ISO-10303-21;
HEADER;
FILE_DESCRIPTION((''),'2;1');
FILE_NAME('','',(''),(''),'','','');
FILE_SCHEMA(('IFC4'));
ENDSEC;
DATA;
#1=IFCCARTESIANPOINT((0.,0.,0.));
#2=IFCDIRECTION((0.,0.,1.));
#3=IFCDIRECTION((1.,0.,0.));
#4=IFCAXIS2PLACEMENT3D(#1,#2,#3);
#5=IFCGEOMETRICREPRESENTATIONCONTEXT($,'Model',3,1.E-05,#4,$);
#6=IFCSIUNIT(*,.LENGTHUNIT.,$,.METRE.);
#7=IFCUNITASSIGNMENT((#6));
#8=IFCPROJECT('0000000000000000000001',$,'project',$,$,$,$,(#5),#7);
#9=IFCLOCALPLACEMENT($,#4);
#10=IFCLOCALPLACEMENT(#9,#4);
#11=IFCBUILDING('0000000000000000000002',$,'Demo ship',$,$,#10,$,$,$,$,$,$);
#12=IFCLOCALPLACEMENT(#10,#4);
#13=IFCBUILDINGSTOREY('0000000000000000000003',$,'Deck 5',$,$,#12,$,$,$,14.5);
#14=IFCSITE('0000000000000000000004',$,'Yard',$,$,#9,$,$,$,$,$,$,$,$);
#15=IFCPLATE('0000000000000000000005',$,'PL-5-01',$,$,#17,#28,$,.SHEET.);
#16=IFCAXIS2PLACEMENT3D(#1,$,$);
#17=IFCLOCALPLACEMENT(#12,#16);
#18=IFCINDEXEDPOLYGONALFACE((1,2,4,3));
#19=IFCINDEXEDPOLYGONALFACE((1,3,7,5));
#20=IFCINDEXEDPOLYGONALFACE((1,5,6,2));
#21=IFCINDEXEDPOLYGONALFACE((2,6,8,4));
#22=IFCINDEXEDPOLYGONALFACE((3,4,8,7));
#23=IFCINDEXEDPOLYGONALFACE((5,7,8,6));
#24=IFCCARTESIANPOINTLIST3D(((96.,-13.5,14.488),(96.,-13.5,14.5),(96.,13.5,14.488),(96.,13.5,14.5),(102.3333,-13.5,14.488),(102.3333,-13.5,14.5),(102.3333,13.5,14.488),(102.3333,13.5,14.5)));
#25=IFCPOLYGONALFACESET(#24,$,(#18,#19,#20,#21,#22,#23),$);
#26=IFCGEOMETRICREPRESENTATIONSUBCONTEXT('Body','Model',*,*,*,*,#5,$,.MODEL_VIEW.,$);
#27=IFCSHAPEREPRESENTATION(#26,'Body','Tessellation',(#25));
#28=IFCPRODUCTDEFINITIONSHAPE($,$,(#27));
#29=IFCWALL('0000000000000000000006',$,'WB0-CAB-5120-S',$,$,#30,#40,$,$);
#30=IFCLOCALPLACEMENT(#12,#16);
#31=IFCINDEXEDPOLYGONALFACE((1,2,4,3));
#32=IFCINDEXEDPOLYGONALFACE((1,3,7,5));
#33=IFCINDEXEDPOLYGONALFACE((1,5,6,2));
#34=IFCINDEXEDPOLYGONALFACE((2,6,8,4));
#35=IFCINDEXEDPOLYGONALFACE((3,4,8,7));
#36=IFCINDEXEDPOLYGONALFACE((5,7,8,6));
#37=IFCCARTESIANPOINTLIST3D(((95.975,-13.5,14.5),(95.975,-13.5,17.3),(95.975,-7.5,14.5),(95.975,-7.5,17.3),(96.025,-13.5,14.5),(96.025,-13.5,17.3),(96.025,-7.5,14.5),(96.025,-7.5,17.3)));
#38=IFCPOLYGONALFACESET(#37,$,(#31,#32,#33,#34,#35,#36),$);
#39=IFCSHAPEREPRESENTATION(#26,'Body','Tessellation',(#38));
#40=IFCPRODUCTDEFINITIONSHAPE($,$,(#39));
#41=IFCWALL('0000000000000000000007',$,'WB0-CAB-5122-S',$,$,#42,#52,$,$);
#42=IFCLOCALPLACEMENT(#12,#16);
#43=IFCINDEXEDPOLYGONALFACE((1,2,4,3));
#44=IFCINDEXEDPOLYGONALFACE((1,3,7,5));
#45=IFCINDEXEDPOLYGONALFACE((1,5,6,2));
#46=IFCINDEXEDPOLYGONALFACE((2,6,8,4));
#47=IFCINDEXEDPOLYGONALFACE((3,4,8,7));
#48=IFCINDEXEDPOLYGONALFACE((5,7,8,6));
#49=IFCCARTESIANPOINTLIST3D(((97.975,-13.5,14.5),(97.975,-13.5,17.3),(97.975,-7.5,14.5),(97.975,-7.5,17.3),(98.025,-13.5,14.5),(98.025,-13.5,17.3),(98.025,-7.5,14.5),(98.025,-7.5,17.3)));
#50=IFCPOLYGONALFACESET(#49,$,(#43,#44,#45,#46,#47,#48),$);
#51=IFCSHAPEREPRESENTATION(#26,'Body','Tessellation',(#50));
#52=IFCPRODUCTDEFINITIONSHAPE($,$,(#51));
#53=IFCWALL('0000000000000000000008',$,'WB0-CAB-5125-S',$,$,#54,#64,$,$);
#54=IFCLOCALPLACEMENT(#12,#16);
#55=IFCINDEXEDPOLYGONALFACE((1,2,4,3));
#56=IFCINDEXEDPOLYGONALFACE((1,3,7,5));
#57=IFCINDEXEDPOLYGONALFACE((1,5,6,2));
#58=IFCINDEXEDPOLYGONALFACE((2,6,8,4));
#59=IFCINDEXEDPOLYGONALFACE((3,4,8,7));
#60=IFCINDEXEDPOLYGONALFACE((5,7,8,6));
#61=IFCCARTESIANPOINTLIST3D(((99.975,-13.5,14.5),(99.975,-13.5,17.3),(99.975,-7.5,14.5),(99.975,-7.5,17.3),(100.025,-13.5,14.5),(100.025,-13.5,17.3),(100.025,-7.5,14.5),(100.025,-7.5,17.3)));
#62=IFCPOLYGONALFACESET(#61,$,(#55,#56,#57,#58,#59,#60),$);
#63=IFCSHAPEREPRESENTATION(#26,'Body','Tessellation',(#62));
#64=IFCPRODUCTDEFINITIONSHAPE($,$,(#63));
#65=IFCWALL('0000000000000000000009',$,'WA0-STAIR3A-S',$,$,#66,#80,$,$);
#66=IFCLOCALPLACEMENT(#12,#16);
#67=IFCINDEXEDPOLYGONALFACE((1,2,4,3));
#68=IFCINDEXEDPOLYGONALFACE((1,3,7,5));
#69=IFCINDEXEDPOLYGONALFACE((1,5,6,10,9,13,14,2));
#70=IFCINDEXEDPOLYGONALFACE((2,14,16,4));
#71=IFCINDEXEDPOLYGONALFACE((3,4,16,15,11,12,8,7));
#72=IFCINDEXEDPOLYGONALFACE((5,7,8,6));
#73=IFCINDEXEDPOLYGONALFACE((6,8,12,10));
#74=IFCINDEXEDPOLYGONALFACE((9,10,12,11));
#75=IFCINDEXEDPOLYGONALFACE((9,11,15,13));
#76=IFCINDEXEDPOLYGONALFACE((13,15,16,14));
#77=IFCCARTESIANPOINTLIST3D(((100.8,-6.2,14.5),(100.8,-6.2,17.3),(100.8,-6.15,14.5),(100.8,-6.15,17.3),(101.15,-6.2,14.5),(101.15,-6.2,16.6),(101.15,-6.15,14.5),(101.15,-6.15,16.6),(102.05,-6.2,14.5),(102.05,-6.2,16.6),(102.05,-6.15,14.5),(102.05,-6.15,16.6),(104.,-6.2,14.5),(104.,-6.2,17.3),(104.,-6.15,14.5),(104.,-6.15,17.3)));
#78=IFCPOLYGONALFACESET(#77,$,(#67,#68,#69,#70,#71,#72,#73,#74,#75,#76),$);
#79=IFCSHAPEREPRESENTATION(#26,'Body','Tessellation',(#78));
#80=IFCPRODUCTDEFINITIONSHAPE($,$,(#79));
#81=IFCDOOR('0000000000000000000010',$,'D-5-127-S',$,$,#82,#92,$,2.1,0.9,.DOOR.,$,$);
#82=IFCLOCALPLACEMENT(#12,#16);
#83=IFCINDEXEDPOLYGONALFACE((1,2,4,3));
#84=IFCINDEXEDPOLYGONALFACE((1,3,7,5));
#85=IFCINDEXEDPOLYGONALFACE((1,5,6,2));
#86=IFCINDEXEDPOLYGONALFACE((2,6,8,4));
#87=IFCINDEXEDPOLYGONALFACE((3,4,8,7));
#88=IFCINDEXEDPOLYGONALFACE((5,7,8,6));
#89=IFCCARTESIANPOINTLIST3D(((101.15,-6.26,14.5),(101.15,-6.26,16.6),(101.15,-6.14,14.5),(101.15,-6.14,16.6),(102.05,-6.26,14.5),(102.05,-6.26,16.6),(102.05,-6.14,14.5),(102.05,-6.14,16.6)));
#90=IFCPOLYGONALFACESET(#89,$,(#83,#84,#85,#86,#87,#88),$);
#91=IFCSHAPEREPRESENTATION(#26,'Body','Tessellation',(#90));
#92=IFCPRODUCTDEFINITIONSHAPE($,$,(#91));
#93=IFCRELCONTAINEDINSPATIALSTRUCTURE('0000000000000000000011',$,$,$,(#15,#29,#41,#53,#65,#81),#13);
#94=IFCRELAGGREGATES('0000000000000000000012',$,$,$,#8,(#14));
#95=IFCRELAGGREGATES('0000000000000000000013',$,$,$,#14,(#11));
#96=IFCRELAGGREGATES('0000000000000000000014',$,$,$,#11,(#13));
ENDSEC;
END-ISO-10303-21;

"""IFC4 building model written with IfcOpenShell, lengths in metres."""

from ifc_helpers import new_model, si_unit, frame, frame_2d, origin, origin_with_axes, place, context, subcontext, project, spatial, rectangle, extrude, element, fill, save


model = new_model("IFC4")

# Units and contexts
model_context = context("Model", 3, precision=1e-05, world=origin_with_axes())
body_context = subcontext(model_context, "Body", "Model", "MODEL_VIEW")
ifc_project = project(units=[si_unit("LENGTHUNIT", "METRE")], contexts=[model_context])

# Site, building, storey
site_placement = place(None, origin_with_axes())
site = spatial("IfcSite", under=ifc_project, at=site_placement, Name="Yard")
building_placement = place(site_placement, origin_with_axes())
building = spatial("IfcBuilding", under=site, at=building_placement, Name="Demo ship")
storey_placement = place(building_placement, origin_with_axes())
storey = spatial("IfcBuildingStorey", under=building, at=storey_placement, Name="Deck 5", Elevation=14.5)

# Plate
plate_placement = place(storey_placement, frame((96.0, -13.5, 14.488), z_axis=(0.0, 0.0, 1.0), x_axis=(1.0, 0.0, 0.0)))
element("IfcPlate", 1, at=plate_placement, inside=storey, Name="PL-5-01", PredefinedType="SHEET", context=body_context, shape_type="SweptSolid", body=[
    extrude(rectangle(XDim=6.3333, YDim=27.0, at=frame_2d((3.1666, 13.5))), origin(), (0.0, 0.0, 1.0), 0.012),
])

# Walls
for number, where, z_axis, x_axis, name in (
    (2, (95.975, -13.5, 14.5), (0.0, 0.0, 1.0), (1.0, 0.0, 0.0), "WB0-CAB-5120-S"),
    (3, (97.975, -13.5, 14.5), (0.0, 0.0, 1.0), (1.0, 0.0, 0.0), "WB0-CAB-5122-S"),
    (4, (99.975, -13.5, 14.5), (0.0, 0.0, 1.0), (1.0, 0.0, 0.0), "WB0-CAB-5125-S"),
):
    element("IfcWall", number, at=place(storey_placement, frame(where, z_axis=z_axis, x_axis=x_axis)), inside=storey, Name=name, context=body_context, shape_type="SweptSolid", body=[
        extrude(rectangle(XDim=0.05, YDim=6.0, at=frame_2d((0.025, 3.0))), origin(), (0.0, 0.0, 1.0), 2.8),
    ])

# Wall, opening, door
wall_1_placement = place(storey_placement, frame((100.8, -6.2, 14.5), z_axis=(0.0, 0.0, 1.0), x_axis=(1.0, 0.0, 0.0)))
wall_1 = element("IfcWall", 5, at=wall_1_placement, inside=storey, Name="WA0-STAIR3A-S", context=body_context, shape_type="SweptSolid", body=[
    extrude(rectangle(XDim=3.2, YDim=0.05, at=frame_2d((1.6, 0.025))), origin(), (0.0, 0.0, 1.0), 2.8),
])
opening_1_placement = place(None, frame((101.15, -6.26, 14.5), z_axis=(0.0, 0.0, 1.0), x_axis=(1.0, 0.0, 0.0)))
opening_1 = element("IfcOpeningElement", 6, at=opening_1_placement, cuts=wall_1, context=body_context, shape_type="SweptSolid", body=[
    extrude(rectangle(XDim=0.9, YDim=0.12, at=frame_2d((0.45, 0.06))), origin(), (0.0, 0.0, 1.0), 2.1),
])
door_1_placement = place(storey_placement, frame((101.15, -6.26, 14.5), z_axis=(0.0, 0.0, 1.0), x_axis=(1.0, 0.0, 0.0)))
door_1 = element("IfcDoor", 7, at=door_1_placement, inside=storey, Name="D-5-127-S", OverallHeight=2.1, OverallWidth=0.9, PredefinedType="DOOR", context=body_context, shape_type="SweptSolid", body=[
    extrude(rectangle(XDim=0.9, YDim=0.12, at=frame_2d((0.45, 0.06))), origin(), (0.0, 0.0, 1.0), 2.1),
])
fill(opening_1, door_1)

save(model, "model.ifc")
